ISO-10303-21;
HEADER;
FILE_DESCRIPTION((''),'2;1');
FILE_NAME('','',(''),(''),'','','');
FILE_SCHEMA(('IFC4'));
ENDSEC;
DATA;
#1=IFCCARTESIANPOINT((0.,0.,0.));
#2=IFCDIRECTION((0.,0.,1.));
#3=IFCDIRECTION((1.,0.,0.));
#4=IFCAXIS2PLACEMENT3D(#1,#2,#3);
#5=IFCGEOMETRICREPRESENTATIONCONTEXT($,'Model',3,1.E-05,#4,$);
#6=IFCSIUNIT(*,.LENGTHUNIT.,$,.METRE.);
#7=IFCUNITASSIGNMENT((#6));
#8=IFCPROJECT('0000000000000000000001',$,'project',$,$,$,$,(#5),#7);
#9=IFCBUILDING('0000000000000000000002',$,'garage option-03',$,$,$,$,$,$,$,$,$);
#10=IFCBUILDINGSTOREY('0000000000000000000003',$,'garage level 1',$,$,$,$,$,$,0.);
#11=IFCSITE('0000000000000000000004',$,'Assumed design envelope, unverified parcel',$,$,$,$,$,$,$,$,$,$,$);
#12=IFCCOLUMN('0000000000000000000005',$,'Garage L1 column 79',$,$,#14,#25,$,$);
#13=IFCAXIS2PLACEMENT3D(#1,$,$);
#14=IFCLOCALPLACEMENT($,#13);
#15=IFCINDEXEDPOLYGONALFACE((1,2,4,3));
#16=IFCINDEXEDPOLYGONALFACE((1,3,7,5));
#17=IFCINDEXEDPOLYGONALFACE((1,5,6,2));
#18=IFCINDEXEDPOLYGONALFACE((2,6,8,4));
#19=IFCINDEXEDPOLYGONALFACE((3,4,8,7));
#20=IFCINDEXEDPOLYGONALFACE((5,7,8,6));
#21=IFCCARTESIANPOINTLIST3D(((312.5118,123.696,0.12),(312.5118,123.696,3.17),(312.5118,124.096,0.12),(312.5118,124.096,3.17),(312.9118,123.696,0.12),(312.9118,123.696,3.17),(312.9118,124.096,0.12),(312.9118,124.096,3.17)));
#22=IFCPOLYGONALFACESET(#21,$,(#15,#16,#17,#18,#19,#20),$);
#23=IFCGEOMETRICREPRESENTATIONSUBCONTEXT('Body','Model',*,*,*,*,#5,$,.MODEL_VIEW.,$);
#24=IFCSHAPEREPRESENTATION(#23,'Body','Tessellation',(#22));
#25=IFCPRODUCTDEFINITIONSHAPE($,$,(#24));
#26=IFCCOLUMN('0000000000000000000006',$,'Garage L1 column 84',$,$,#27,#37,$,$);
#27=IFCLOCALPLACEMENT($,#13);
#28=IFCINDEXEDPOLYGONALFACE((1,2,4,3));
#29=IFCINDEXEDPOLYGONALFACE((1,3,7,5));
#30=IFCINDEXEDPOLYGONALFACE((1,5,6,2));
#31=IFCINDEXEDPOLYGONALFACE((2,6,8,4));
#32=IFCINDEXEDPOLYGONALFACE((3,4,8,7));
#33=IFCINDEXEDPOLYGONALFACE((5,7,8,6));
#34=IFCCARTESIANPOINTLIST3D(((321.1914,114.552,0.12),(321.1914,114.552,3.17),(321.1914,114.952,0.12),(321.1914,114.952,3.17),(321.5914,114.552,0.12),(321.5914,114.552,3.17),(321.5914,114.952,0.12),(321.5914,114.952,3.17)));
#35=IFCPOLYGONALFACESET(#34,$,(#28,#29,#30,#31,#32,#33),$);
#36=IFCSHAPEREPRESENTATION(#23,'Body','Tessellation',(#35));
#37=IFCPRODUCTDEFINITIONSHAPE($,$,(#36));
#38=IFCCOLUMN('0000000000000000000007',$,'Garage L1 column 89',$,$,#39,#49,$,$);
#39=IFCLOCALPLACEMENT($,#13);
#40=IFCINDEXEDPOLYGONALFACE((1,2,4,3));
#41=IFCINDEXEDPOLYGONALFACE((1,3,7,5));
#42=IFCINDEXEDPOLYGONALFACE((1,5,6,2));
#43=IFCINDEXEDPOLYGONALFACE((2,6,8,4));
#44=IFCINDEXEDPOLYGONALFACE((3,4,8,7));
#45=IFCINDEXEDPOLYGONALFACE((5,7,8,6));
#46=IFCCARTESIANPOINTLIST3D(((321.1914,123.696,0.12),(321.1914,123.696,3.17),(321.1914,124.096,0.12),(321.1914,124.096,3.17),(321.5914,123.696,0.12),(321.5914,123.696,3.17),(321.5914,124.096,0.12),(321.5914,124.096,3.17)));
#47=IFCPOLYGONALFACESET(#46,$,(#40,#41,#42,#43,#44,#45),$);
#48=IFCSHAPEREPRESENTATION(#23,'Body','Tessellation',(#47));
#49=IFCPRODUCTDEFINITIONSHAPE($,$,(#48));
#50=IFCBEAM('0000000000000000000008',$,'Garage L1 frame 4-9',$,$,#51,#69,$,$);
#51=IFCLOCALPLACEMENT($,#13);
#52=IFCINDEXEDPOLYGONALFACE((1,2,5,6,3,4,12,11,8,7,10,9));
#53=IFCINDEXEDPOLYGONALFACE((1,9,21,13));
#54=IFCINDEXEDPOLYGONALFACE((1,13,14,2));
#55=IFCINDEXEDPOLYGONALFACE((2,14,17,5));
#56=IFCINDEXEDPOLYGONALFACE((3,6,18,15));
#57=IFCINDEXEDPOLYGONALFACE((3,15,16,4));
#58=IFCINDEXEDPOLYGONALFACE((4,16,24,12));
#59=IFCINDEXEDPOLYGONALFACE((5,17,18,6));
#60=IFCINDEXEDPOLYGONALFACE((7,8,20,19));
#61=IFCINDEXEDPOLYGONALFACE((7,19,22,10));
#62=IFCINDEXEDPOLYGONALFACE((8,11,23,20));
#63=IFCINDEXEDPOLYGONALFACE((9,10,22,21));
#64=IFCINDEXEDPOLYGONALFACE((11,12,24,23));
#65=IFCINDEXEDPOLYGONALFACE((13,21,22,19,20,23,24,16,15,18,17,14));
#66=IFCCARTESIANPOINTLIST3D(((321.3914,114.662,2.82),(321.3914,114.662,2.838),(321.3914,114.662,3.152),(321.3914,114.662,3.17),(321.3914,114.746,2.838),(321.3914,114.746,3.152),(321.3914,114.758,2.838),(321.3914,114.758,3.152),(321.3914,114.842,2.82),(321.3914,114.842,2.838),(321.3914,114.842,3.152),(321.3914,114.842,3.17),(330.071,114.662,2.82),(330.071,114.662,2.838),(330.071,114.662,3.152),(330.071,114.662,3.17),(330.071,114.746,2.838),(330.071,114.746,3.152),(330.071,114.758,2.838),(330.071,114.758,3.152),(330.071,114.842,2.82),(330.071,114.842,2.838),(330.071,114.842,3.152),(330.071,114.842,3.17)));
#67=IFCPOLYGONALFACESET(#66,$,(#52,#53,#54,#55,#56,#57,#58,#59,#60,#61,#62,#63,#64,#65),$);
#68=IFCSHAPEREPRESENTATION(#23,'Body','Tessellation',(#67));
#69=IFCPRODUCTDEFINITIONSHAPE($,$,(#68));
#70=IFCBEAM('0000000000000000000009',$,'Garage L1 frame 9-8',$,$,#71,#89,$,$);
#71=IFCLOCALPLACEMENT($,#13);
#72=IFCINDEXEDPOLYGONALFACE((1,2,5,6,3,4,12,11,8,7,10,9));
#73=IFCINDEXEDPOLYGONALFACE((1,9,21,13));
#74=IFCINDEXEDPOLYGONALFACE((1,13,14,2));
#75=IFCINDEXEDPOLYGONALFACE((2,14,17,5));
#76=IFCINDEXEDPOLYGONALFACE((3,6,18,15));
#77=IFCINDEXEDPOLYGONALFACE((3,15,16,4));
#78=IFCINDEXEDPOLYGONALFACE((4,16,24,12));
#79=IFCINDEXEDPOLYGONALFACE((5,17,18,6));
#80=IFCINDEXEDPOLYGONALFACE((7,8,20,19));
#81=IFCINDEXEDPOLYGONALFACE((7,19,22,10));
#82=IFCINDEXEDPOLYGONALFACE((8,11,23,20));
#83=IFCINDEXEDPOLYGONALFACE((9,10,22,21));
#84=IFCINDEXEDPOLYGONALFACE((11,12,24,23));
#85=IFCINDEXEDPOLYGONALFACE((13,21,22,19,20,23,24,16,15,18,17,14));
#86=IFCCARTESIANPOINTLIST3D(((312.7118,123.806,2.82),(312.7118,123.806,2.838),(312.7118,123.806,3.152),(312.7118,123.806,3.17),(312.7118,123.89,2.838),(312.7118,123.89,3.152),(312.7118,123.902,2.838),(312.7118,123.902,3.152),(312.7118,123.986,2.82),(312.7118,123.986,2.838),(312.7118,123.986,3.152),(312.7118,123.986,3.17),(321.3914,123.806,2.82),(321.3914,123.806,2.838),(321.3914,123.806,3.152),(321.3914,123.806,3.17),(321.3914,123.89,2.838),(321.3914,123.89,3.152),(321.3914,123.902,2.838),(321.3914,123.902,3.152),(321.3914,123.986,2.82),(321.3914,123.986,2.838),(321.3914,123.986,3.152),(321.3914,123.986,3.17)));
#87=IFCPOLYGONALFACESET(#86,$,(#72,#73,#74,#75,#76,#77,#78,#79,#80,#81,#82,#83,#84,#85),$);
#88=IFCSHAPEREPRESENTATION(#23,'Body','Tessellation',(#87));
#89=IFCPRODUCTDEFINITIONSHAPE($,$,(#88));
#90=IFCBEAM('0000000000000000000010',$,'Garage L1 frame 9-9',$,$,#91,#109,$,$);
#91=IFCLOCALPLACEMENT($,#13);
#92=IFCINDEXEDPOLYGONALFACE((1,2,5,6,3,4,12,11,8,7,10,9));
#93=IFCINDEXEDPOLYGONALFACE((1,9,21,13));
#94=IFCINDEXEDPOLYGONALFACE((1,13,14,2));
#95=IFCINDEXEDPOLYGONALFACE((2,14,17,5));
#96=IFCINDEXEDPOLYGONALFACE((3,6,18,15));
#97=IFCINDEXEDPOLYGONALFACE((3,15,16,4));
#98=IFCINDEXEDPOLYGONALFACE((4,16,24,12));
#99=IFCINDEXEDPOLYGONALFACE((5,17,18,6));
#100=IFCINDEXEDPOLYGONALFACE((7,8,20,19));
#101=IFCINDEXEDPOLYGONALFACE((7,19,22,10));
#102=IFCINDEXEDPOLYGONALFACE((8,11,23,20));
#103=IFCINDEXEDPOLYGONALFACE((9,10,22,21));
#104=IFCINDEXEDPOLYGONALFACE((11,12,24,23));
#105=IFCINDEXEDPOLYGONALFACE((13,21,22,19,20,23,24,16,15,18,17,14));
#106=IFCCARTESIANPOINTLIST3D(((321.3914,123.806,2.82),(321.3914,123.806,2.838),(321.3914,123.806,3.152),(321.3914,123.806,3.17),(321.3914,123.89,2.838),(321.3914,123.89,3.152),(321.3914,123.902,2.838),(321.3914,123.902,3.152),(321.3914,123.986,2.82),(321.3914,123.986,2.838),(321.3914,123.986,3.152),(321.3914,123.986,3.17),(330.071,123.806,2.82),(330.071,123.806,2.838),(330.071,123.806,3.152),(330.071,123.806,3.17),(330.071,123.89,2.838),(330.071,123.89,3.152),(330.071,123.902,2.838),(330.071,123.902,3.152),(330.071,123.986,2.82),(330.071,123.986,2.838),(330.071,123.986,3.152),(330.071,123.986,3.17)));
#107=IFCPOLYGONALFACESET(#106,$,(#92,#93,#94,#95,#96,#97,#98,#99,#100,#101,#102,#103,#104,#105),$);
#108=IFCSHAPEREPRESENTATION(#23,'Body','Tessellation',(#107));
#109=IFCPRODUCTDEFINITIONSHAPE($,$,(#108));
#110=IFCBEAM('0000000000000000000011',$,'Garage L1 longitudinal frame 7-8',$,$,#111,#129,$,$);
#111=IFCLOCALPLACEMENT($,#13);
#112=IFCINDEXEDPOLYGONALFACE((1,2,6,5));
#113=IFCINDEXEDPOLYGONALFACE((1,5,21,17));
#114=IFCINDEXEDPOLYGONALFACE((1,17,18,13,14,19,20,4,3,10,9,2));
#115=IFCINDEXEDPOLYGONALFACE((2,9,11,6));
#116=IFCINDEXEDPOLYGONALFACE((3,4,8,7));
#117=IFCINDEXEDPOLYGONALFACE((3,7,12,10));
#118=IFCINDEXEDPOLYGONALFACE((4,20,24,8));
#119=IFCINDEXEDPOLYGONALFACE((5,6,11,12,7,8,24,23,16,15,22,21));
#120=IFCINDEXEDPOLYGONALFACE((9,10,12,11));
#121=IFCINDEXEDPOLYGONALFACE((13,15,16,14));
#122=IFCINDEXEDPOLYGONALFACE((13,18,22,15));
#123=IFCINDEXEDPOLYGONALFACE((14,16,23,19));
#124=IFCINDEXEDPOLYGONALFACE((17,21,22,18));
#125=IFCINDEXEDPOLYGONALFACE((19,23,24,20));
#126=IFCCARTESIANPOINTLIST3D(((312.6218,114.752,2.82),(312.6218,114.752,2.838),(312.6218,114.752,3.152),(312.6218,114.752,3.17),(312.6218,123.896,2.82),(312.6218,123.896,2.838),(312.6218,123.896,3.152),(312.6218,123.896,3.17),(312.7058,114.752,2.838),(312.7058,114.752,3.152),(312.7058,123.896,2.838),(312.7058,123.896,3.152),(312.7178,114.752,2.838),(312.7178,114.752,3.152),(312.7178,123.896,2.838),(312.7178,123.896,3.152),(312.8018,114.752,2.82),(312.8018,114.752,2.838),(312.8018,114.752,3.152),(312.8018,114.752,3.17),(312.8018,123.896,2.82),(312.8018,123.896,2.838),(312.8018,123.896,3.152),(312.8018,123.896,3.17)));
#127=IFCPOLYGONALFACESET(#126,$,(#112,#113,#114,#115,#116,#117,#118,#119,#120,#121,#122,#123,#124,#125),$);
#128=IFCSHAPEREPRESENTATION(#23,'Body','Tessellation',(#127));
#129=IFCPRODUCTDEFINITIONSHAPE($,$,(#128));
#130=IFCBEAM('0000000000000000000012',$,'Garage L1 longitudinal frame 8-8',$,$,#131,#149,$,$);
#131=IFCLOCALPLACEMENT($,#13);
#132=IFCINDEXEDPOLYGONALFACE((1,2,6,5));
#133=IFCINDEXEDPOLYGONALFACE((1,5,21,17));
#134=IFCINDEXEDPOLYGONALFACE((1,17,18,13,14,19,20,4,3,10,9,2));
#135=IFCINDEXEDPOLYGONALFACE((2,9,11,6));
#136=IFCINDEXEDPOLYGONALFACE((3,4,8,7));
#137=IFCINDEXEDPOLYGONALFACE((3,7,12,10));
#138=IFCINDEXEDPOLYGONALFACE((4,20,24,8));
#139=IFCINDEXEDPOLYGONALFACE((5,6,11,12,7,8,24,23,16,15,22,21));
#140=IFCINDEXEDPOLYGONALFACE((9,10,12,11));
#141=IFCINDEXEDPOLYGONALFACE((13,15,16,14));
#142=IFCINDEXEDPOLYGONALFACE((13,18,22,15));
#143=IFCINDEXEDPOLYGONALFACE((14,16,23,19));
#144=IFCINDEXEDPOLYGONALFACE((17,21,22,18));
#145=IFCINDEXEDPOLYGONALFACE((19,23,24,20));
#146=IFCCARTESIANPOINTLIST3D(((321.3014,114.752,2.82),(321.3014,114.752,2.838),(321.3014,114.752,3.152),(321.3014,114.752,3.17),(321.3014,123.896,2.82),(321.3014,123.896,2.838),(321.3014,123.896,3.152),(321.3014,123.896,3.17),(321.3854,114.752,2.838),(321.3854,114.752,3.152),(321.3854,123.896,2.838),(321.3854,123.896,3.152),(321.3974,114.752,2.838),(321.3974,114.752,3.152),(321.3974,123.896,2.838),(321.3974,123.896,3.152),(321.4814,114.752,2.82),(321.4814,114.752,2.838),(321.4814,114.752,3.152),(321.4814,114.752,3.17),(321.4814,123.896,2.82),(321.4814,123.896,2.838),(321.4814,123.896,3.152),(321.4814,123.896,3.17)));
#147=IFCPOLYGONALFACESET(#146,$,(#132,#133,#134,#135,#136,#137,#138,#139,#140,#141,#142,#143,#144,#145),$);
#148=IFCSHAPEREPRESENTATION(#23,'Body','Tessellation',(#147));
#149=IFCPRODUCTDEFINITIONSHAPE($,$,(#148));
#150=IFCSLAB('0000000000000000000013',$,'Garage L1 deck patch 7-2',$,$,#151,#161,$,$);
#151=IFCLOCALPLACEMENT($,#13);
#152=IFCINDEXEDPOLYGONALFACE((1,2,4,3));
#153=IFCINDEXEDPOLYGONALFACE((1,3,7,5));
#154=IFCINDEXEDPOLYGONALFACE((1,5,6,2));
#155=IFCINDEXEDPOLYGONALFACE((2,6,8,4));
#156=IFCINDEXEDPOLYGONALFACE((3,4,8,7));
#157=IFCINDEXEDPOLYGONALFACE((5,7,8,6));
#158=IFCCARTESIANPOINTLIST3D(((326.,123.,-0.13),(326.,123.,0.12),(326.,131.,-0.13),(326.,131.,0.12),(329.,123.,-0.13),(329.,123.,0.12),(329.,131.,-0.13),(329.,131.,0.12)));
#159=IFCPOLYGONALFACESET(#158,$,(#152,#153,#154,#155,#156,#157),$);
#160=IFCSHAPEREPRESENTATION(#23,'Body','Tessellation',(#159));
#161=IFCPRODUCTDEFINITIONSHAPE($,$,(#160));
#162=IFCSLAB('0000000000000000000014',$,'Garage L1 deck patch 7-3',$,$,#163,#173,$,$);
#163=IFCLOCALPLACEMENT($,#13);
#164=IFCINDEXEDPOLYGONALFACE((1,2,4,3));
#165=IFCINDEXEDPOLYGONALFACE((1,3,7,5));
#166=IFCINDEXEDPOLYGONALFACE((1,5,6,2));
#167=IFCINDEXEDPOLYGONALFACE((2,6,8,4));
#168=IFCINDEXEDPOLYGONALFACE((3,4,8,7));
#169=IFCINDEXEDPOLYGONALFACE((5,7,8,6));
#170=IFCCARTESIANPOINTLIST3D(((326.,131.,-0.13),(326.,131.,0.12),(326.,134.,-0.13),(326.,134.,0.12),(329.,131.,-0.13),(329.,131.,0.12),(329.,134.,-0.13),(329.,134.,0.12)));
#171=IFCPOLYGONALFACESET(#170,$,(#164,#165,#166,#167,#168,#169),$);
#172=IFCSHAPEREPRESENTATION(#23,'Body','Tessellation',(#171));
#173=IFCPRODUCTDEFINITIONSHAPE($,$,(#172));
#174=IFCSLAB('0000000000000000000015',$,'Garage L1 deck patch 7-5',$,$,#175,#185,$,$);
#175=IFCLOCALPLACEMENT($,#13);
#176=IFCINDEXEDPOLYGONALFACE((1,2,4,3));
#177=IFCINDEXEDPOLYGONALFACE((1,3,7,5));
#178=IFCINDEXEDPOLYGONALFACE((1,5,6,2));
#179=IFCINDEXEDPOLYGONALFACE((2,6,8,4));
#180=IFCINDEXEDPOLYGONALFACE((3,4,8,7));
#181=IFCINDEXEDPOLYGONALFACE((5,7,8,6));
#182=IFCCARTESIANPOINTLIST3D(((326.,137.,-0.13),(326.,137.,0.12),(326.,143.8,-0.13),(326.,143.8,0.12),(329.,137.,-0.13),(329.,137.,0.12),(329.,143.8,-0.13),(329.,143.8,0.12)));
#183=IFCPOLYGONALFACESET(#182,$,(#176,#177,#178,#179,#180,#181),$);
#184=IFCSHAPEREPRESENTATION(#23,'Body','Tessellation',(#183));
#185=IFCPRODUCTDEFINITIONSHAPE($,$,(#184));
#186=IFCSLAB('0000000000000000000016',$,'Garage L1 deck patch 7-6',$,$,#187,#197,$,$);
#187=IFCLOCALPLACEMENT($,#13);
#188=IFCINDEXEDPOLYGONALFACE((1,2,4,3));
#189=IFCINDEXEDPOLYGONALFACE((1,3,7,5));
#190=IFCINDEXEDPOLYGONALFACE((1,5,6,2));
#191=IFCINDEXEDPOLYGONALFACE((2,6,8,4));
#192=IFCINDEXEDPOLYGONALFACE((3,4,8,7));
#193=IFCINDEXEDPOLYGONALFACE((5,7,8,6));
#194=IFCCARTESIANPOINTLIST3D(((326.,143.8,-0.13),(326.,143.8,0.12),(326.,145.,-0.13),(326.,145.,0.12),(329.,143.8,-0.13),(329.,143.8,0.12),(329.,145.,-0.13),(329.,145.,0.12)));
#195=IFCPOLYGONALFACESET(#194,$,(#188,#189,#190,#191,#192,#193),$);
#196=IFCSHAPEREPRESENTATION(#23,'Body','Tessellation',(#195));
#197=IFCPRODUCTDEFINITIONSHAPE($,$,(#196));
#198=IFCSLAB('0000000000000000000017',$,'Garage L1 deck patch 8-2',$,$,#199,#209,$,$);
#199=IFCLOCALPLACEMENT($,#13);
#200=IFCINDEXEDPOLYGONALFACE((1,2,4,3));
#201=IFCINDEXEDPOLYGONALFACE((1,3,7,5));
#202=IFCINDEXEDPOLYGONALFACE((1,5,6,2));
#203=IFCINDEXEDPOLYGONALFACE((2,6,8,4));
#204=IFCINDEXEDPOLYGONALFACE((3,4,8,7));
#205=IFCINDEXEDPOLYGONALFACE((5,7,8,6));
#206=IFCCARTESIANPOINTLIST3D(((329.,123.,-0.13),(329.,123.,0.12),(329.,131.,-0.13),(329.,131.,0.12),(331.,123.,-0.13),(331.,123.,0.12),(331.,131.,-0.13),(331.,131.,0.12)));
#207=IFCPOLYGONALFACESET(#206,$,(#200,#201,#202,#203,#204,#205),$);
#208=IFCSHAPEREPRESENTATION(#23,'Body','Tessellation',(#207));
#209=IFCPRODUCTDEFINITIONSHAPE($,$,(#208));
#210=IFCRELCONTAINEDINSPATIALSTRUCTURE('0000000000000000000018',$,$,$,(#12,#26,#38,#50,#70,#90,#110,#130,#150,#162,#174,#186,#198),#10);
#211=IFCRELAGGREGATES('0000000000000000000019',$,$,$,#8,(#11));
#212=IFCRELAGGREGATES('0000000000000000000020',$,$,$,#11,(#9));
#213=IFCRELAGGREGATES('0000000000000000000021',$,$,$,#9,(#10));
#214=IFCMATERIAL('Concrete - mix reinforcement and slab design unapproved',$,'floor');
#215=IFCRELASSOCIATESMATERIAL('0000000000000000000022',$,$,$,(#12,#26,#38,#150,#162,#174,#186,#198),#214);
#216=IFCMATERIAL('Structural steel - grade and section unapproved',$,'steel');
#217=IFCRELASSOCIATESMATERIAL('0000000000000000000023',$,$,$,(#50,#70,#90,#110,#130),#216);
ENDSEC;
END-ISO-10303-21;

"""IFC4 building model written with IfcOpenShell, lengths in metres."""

from ifc_helpers import new_model, si_unit, frame, origin_with_axes, place, context, subcontext, project, spatial, rectangle, i_section, extrude, material, element, save


model = new_model("IFC4")

# Units and contexts
model_context = context("Model", 3, precision=1e-05, world=origin_with_axes())
body_context = subcontext(model_context, "Body", "Model", "MODEL_VIEW")
ifc_project = project(units=[si_unit("LENGTHUNIT", "METRE")], contexts=[model_context])

# Site, building, storey
site = spatial("IfcSite", under=ifc_project, Name="Assumed design envelope, unverified parcel")
building = spatial("IfcBuilding", under=site, Name="garage option-03")
storey = spatial("IfcBuildingStorey", under=building, Name="garage level 1", Elevation=0.0)

# Columns
ifc_material_1 = material(Name="Concrete - mix reinforcement and slab design unapproved", Category="floor")
for number, where, z_axis, x_axis, name in (
    (1, (312.7118, 123.896, 0.12), (0.0, 0.0, 1.0), (1.0, 0.0, 0.0), "Garage L1 column 79"),
    (2, (321.3914, 114.752, 0.12), (0.0, 0.0, 1.0), (1.0, 0.0, 0.0), "Garage L1 column 84"),
    (3, (321.3914, 123.896, 0.12), (0.0, 0.0, 1.0), (1.0, 0.0, 0.0), "Garage L1 column 89"),
):
    element("IfcColumn", number, at=place(None, frame(where, z_axis=z_axis, x_axis=x_axis)), inside=storey, material=ifc_material_1, Name=name, context=body_context, shape_type="SweptSolid", body=[
        extrude(rectangle(XDim=0.4, YDim=0.4), origin_with_axes(), (0.0, 0.0, 1.0), 3.05),
    ])

# Beams
ifc_material_2 = material(Name="Structural steel - grade and section unapproved", Category="steel")
beam_1_placement = place(None, frame((321.3914, 114.752, 2.995), z_axis=(1.0, 0.0, 0.0), x_axis=(0.0, 1.0, 0.0)))
element("IfcBeam", 4, at=beam_1_placement, inside=storey, material=ifc_material_2, Name="Garage L1 frame 4-9", context=body_context, shape_type="SweptSolid", body=[
    extrude(i_section(OverallWidth=0.18, OverallDepth=0.35, WebThickness=0.012, FlangeThickness=0.018, FilletRadius=0.0), origin_with_axes(), (0.0, 0.0, 1.0), 8.6796),
])
beam_2_placement = place(None, frame((312.7118, 123.896, 2.995), z_axis=(1.0, 0.0, 0.0), x_axis=(0.0, 1.0, 0.0)))
element("IfcBeam", 5, at=beam_2_placement, inside=storey, material=ifc_material_2, Name="Garage L1 frame 9-8", context=body_context, shape_type="SweptSolid", body=[
    extrude(i_section(OverallWidth=0.18, OverallDepth=0.35, WebThickness=0.012, FlangeThickness=0.018, FilletRadius=0.0), origin_with_axes(), (0.0, 0.0, 1.0), 8.6796),
])
beam_3_placement = place(None, frame((321.3914, 123.896, 2.995), z_axis=(1.0, 0.0, 0.0), x_axis=(0.0, 1.0, 0.0)))
element("IfcBeam", 6, at=beam_3_placement, inside=storey, material=ifc_material_2, Name="Garage L1 frame 9-9", context=body_context, shape_type="SweptSolid", body=[
    extrude(i_section(OverallWidth=0.18, OverallDepth=0.35, WebThickness=0.012, FlangeThickness=0.018, FilletRadius=0.0), origin_with_axes(), (0.0, 0.0, 1.0), 8.6796),
])
for number, where, z_axis, x_axis, name in (
    (7, (312.7118, 114.752, 2.995), (0.0, 1.0, 0.0), (-1.0, 0.0, 0.0), "Garage L1 longitudinal frame 7-8"),
    (8, (321.3914, 114.752, 2.995), (0.0, 1.0, 0.0), (-1.0, 0.0, 0.0), "Garage L1 longitudinal frame 8-8"),
):
    element("IfcBeam", number, at=place(None, frame(where, z_axis=z_axis, x_axis=x_axis)), inside=storey, material=ifc_material_2, Name=name, context=body_context, shape_type="SweptSolid", body=[
        extrude(i_section(OverallWidth=0.18, OverallDepth=0.35, WebThickness=0.012, FlangeThickness=0.018, FilletRadius=0.0), origin_with_axes(), (0.0, 0.0, 1.0), 9.144),
    ])

# Slabs
slab_1_placement = place(None, frame((327.5, 127.0, -0.13), z_axis=(0.0, 0.0, 1.0), x_axis=(1.0, 0.0, 0.0)))
element("IfcSlab", 9, at=slab_1_placement, inside=storey, material=ifc_material_1, Name="Garage L1 deck patch 7-2", context=body_context, shape_type="SweptSolid", body=[
    extrude(rectangle(XDim=3.0, YDim=8.0), origin_with_axes(), (0.0, 0.0, 1.0), 0.25),
])
slab_2_placement = place(None, frame((327.5, 132.5, -0.13), z_axis=(0.0, 0.0, 1.0), x_axis=(1.0, 0.0, 0.0)))
element("IfcSlab", 10, at=slab_2_placement, inside=storey, material=ifc_material_1, Name="Garage L1 deck patch 7-3", context=body_context, shape_type="SweptSolid", body=[
    extrude(rectangle(XDim=3.0, YDim=3.0), origin_with_axes(), (0.0, 0.0, 1.0), 0.25),
])
slab_3_placement = place(None, frame((327.5, 140.4, -0.13), z_axis=(0.0, 0.0, 1.0), x_axis=(1.0, 0.0, 0.0)))
element("IfcSlab", 11, at=slab_3_placement, inside=storey, material=ifc_material_1, Name="Garage L1 deck patch 7-5", context=body_context, shape_type="SweptSolid", body=[
    extrude(rectangle(XDim=3.0, YDim=6.8), origin_with_axes(), (0.0, 0.0, 1.0), 0.25),
])
slab_4_placement = place(None, frame((327.5, 144.4, -0.13), z_axis=(0.0, 0.0, 1.0), x_axis=(1.0, 0.0, 0.0)))
element("IfcSlab", 12, at=slab_4_placement, inside=storey, material=ifc_material_1, Name="Garage L1 deck patch 7-6", context=body_context, shape_type="SweptSolid", body=[
    extrude(rectangle(XDim=3.0, YDim=1.2), origin_with_axes(), (0.0, 0.0, 1.0), 0.25),
])
slab_5_placement = place(None, frame((330.0, 127.0, -0.13), z_axis=(0.0, 0.0, 1.0), x_axis=(1.0, 0.0, 0.0)))
element("IfcSlab", 13, at=slab_5_placement, inside=storey, material=ifc_material_1, Name="Garage L1 deck patch 8-2", context=body_context, shape_type="SweptSolid", body=[
    extrude(rectangle(XDim=2.0, YDim=8.0), origin_with_axes(), (0.0, 0.0, 1.0), 0.25),
])

save(model, "model.ifc")
